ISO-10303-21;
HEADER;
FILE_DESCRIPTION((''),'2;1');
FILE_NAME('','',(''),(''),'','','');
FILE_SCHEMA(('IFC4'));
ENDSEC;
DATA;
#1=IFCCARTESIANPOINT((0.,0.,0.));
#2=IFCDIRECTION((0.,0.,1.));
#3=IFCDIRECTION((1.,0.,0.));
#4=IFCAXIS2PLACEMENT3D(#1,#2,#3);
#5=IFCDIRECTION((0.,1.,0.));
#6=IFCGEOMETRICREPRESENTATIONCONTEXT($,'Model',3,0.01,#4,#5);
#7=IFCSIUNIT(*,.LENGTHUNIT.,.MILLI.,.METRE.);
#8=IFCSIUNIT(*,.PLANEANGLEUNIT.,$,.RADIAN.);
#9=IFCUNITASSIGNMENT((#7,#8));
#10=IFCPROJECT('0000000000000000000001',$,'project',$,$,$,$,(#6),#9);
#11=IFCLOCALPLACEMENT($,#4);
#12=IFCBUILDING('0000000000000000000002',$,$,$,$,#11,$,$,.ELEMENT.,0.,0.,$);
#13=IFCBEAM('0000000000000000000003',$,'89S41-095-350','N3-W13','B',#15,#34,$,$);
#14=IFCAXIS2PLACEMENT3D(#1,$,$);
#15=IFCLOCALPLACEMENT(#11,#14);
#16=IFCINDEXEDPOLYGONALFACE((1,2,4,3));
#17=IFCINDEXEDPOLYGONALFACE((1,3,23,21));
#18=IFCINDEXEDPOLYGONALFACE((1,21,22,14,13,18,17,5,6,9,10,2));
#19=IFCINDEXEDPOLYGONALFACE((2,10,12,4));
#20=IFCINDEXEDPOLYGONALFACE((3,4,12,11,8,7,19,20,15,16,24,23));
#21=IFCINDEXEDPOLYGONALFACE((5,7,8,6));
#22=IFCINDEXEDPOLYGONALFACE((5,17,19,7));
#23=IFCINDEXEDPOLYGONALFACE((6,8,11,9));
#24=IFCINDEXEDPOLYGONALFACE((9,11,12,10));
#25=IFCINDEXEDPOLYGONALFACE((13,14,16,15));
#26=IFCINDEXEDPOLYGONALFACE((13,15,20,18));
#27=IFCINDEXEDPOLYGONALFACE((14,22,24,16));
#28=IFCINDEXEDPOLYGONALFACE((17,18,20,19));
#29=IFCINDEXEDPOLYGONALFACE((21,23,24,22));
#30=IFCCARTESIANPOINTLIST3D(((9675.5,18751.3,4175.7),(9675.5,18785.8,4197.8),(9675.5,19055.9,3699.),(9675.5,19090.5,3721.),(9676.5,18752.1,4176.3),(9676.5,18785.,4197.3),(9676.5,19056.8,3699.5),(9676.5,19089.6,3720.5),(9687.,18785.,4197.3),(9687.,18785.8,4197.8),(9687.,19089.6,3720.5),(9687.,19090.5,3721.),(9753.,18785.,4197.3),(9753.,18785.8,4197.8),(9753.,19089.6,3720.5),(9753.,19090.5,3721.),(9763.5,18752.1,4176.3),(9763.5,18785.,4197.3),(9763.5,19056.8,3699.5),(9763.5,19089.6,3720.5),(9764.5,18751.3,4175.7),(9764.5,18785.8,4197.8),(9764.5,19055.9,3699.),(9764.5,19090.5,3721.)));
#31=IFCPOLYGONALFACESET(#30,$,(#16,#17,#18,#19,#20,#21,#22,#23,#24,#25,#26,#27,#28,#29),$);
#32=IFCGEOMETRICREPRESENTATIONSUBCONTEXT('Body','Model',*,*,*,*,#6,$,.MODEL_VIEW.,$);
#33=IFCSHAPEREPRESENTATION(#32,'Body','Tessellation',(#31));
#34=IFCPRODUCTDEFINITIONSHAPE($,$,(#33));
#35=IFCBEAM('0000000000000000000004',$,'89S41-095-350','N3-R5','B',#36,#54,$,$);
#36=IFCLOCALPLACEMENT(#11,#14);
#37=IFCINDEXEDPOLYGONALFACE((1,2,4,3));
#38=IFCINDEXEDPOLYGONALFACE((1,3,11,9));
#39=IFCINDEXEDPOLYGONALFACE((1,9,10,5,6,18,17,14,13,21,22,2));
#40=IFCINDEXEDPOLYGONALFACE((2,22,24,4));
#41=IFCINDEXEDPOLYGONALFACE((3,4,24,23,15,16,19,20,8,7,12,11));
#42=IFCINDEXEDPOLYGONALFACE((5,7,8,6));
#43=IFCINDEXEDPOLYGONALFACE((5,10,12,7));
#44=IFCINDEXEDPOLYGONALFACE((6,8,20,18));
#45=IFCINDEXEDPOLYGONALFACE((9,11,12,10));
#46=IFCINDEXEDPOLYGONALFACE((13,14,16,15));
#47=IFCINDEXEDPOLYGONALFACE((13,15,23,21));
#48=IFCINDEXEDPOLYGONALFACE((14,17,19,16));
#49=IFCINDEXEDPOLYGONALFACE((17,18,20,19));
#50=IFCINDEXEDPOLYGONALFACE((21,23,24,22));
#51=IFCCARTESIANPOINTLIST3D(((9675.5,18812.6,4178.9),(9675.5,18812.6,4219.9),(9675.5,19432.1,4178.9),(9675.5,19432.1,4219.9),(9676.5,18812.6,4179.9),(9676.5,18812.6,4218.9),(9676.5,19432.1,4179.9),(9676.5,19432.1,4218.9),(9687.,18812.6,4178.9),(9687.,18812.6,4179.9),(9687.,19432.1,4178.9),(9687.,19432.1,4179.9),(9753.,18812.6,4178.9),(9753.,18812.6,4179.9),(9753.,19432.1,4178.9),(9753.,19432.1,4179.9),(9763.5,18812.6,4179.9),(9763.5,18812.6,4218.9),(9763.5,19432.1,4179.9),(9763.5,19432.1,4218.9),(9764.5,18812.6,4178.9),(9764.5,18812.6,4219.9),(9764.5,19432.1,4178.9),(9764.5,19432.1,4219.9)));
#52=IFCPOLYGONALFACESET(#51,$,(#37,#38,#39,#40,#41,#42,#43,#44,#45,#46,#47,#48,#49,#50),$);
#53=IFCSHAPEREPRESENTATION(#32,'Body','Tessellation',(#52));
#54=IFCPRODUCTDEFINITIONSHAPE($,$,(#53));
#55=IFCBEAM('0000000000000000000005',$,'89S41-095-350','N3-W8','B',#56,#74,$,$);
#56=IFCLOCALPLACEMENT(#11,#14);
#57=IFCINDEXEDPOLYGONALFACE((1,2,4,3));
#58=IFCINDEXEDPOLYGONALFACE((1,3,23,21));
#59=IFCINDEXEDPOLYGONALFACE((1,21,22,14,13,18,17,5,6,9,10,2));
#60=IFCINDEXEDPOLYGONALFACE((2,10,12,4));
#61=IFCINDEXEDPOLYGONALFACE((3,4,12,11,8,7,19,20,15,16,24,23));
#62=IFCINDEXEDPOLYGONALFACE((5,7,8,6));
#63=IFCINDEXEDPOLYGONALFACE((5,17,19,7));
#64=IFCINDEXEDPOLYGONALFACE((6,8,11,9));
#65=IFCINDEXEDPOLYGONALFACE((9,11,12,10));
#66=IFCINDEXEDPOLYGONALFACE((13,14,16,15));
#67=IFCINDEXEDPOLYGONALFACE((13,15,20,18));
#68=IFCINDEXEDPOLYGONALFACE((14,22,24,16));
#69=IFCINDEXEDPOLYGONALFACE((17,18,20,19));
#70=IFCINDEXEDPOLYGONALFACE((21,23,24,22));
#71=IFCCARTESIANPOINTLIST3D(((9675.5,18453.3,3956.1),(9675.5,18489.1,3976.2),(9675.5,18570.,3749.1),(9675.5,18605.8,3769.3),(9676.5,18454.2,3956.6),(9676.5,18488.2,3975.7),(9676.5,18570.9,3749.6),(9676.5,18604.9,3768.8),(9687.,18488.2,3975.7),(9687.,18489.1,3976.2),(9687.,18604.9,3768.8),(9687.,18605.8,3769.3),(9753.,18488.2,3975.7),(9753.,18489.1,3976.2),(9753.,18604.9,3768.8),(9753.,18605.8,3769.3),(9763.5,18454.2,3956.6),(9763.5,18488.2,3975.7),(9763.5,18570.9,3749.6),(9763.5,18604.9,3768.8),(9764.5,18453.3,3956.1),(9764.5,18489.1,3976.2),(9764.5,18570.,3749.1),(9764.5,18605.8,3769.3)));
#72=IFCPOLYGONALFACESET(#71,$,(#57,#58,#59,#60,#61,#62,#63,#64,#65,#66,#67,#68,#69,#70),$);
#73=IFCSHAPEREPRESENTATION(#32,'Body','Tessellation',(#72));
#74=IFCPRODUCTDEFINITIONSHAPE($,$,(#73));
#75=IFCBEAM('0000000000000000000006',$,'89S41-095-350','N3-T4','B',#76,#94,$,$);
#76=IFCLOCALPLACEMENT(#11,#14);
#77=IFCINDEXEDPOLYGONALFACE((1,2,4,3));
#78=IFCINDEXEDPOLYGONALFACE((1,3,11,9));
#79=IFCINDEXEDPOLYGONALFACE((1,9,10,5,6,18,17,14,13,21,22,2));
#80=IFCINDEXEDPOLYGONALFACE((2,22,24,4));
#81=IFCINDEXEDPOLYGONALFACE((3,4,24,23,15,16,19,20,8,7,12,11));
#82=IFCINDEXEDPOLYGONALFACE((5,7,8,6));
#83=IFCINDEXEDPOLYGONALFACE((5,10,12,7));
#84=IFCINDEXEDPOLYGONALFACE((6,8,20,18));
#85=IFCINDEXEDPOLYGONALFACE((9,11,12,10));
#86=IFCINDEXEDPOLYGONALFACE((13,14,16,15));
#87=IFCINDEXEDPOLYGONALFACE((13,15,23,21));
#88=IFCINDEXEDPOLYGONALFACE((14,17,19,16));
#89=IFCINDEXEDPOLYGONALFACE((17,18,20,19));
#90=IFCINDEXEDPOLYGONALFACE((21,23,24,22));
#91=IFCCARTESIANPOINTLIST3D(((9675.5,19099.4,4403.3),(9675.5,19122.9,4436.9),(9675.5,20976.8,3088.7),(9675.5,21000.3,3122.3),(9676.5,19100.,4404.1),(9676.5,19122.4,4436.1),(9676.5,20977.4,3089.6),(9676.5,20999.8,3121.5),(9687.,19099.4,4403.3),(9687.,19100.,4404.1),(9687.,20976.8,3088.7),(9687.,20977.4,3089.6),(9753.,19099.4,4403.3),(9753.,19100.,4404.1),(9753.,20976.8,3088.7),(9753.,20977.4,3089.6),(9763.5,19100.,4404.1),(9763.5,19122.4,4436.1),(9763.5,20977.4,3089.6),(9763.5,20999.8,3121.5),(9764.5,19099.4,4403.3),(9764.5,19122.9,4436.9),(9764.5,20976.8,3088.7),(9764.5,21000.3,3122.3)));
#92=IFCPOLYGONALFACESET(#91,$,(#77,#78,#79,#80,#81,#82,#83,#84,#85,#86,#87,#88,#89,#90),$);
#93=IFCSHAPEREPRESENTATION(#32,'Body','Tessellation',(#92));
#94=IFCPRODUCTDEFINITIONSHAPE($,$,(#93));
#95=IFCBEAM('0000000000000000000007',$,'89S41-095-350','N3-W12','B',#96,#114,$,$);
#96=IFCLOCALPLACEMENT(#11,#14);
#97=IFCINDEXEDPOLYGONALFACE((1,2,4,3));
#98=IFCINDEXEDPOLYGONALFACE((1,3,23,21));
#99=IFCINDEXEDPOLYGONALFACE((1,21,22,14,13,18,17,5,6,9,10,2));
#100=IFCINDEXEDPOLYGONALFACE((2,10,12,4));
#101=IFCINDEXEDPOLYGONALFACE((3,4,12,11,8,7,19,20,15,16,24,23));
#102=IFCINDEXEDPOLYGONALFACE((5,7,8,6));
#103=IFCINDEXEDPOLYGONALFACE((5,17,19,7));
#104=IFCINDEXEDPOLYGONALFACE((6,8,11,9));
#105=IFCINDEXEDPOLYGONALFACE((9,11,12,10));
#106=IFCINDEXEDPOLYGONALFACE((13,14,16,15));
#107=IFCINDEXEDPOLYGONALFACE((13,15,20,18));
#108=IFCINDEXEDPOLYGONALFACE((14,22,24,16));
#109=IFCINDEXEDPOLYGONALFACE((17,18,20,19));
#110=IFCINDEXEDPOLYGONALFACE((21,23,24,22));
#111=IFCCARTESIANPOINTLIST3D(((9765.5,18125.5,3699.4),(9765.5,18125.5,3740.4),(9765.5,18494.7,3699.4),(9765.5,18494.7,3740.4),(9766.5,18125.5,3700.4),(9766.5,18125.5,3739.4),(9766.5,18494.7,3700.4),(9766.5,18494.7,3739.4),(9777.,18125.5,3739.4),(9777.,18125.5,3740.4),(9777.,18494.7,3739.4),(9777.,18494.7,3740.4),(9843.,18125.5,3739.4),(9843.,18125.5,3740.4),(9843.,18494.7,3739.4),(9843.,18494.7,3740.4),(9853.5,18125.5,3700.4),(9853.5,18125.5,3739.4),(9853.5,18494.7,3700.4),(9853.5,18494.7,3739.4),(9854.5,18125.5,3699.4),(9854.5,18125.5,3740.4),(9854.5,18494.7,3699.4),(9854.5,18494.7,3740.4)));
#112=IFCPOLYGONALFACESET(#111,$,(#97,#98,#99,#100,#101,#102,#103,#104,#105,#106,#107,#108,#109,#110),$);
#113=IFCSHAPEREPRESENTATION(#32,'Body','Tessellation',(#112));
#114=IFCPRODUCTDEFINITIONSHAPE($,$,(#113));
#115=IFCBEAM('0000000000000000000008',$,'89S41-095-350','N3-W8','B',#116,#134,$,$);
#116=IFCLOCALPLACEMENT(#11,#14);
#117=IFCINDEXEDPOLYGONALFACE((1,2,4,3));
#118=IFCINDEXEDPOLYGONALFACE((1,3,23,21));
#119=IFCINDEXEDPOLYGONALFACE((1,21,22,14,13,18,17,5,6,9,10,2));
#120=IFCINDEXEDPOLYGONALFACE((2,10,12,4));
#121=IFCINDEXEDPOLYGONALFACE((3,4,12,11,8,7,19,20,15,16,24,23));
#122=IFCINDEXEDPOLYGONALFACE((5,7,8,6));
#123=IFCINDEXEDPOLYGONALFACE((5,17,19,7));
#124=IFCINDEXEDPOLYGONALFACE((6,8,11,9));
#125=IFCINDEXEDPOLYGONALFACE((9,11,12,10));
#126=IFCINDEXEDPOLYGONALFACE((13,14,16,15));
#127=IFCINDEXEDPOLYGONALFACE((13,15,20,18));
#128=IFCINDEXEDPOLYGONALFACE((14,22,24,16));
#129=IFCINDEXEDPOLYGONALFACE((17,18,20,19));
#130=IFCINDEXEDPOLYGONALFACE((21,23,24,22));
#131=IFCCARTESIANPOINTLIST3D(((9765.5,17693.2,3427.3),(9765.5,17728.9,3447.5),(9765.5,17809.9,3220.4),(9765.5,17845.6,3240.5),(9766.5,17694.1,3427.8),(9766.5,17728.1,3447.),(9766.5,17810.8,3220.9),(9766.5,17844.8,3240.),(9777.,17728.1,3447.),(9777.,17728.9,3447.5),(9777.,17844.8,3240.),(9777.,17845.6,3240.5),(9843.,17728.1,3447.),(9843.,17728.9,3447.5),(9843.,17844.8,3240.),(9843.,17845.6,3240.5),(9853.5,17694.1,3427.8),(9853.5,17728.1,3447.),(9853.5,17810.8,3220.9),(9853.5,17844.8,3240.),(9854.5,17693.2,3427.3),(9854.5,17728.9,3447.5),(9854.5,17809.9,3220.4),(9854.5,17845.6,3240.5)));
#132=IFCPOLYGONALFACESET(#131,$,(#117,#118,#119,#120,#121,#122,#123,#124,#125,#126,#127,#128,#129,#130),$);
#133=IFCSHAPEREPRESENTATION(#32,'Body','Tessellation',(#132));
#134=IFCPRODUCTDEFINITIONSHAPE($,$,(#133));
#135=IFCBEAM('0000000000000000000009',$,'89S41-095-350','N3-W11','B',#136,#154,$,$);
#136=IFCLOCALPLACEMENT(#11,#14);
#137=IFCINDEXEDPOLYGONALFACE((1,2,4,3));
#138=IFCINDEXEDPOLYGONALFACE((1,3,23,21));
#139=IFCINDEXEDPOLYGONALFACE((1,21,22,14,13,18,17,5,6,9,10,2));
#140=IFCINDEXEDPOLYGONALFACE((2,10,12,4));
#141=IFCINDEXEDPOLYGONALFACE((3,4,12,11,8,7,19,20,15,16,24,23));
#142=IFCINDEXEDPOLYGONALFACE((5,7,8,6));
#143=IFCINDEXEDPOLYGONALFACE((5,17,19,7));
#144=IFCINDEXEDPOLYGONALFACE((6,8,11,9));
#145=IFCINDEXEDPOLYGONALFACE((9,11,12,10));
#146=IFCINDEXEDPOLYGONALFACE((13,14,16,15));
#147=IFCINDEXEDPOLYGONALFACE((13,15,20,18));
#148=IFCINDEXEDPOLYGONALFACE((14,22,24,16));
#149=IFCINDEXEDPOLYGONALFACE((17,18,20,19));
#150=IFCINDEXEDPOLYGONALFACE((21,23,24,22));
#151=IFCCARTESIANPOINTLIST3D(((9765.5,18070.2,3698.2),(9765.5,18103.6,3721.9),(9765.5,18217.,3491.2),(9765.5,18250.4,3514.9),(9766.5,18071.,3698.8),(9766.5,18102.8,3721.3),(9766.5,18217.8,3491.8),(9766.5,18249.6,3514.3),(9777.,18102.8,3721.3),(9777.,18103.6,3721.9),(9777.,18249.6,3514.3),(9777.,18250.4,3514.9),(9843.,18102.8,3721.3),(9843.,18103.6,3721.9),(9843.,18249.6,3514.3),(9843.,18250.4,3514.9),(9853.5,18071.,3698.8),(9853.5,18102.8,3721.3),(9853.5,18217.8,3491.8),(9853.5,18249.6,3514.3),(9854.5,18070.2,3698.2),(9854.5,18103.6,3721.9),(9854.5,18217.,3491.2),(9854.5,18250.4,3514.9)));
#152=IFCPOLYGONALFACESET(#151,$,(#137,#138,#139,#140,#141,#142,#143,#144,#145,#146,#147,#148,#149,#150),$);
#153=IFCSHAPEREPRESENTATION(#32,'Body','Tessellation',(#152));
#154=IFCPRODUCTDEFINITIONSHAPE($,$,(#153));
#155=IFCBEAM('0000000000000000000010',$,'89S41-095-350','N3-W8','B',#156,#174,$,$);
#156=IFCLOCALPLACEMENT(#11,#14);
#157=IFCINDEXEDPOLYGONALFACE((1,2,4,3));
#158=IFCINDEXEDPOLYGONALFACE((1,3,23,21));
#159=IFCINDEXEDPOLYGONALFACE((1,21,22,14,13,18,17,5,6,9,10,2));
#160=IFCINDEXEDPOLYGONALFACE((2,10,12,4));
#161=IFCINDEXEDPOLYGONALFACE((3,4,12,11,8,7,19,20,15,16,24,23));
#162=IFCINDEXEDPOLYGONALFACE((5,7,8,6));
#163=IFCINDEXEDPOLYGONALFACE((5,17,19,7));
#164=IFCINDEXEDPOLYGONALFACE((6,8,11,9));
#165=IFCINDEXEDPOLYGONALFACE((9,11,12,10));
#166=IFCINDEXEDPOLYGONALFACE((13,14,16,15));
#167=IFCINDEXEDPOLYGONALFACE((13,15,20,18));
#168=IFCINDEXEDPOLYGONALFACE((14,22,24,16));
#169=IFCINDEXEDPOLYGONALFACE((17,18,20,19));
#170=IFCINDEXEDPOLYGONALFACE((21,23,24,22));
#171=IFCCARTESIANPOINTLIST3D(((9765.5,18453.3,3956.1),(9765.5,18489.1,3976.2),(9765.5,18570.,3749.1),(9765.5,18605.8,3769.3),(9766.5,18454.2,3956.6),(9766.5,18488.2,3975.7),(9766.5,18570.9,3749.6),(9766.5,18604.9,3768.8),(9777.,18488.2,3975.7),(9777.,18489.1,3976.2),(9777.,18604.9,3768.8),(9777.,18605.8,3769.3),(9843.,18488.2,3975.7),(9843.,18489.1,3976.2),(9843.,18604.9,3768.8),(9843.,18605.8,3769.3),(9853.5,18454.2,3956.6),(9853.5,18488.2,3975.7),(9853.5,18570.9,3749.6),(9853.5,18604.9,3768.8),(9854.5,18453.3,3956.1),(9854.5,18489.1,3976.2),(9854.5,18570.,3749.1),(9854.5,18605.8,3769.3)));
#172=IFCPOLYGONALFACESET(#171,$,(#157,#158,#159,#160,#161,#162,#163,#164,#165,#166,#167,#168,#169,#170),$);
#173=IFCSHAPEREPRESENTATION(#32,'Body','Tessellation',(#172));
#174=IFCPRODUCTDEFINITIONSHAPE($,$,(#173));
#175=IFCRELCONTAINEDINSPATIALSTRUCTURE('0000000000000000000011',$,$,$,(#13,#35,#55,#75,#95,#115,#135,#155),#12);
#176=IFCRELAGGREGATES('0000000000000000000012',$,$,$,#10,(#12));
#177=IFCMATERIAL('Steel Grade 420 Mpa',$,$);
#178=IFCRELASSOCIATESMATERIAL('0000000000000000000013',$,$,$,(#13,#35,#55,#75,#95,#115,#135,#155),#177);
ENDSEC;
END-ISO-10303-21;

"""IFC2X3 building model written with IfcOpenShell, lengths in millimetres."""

from ifc_helpers import new_model, si_unit, direction, frame, origin, origin_with_axes, origin_2d_with_axis, place, context, subcontext, project, spatial, c_section, extrude, source, transform, mapped, material, element, save


model = new_model("IFC2X3")

# Units and contexts
model_context = context("Model", 3, precision=0.01, world=origin_with_axes(), true_north=direction((0.0, 1.0, 0.0)))
body_context = subcontext(model_context, "Body", "Model", "MODEL_VIEW")
ifc_project = project(units=[si_unit("LENGTHUNIT", "METRE", prefix="MILLI"), si_unit("PLANEANGLEUNIT", "RADIAN")], contexts=[model_context])

# Building
building_placement = place(None, origin_with_axes())
building = spatial("IfcBuilding", under=ifc_project, at=building_placement, CompositionType="ELEMENT", ElevationOfRefHeight=0.0, ElevationOfTerrain=0.0)

# Shared definitions
ifc_material = material(Name="Steel Grade 420 Mpa")

# Beams
shared_shape_1 = source(origin(), body_context, "Body", "SweptSolid", [
    extrude(c_section(Depth=89.0, Width=41.0, WallThickness=1.0, Girth=11.5, at=origin_2d_with_axis()), origin_with_axes(), (0.0, 0.0, 1.0), 565.8),
])
beam_1_placement = place(None, frame((9720.0, 19073.2, 3710.0), z_axis=(0.0, -0.538498, 0.842627), x_axis=(0.0, 0.842627, 0.538498)))
element("IfcBeam", 1, at=beam_1_placement, inside=building, material=ifc_material, Name="89S41-095-350", Description="N3-W13", ObjectType="B", context=body_context, shape_type="MappedRepresentation", body=[
    mapped(shared_shape_1, transform((0.0, 0.0, 0.0), scale=1.0)),
])
shared_shape_2 = source(origin(), body_context, "Body", "SweptSolid", [
    extrude(c_section(Depth=89.0, Width=41.0, WallThickness=1.0, Girth=11.5, at=origin_2d_with_axis()), origin_with_axes(), (0.0, 0.0, 1.0), 619.5),
])
beam_2_placement = place(None, frame((9720.0, 18812.6, 4199.4), z_axis=(0.0, 1.0, 0.0), x_axis=(0.0, 0.0, -1.0)))
element("IfcBeam", 2, at=beam_2_placement, inside=building, material=ifc_material, Name="89S41-095-350", Description="N3-R5", ObjectType="B", context=body_context, shape_type="MappedRepresentation", body=[
    mapped(shared_shape_2, transform((0.0, 0.0, 0.0), scale=1.0)),
])
shared_shape_3 = source(origin(), body_context, "Body", "SweptSolid", [
    extrude(c_section(Depth=89.0, Width=41.0, WallThickness=1.0, Girth=11.5, at=origin_2d_with_axis()), origin_with_axes(), (0.0, 0.0, 1.0), 237.6),
])
beam_3_placement = place(None, frame((9720.0, 18587.9, 3759.2), z_axis=(0.0, -0.491169, 0.871064), x_axis=(0.0, 0.871064, 0.491169)))
element("IfcBeam", 3, at=beam_3_placement, inside=building, material=ifc_material, Name="89S41-095-350", Description="N3-W8", ObjectType="B", context=body_context, shape_type="MappedRepresentation", body=[
    mapped(shared_shape_3, transform((0.0, 0.0, 0.0), scale=1.0)),
])
shared_shape_4 = source(origin(), body_context, "Body", "SweptSolid", [
    extrude(c_section(Depth=89.0, Width=41.0, WallThickness=1.0, Girth=11.5, at=origin_2d_with_axis()), origin_with_axes(), (0.0, 0.0, 1.0), 2291.9),
])
beam_4_placement = place(None, frame((9720.0, 19111.2, 4420.1), z_axis=(0.0, 0.819152, -0.573576), x_axis=(0.0, -0.573576, -0.819152)))
element("IfcBeam", 4, at=beam_4_placement, inside=building, material=ifc_material, Name="89S41-095-350", Description="N3-T4", ObjectType="B", context=body_context, shape_type="MappedRepresentation", body=[
    mapped(shared_shape_4, transform((0.0, 0.0, 0.0), scale=1.0)),
])
shared_shape_5 = source(origin(), body_context, "Body", "SweptSolid", [
    extrude(c_section(Depth=89.0, Width=41.0, WallThickness=1.0, Girth=11.5, at=origin_2d_with_axis()), origin_with_axes(), (0.0, 0.0, 1.0), 369.2),
])
beam_5_placement = place(None, frame((9810.0, 18494.7, 3719.9), z_axis=(0.0, -1.0, 0.0), x_axis=(0.0, 0.0, 1.0)))
element("IfcBeam", 5, at=beam_5_placement, inside=building, material=ifc_material, Name="89S41-095-350", Description="N3-W12", ObjectType="B", context=body_context, shape_type="MappedRepresentation", body=[
    mapped(shared_shape_5, transform((0.0, 0.0, 0.0), scale=1.0)),
])
shared_shape_6 = source(origin(), body_context, "Body", "SweptSolid", [
    extrude(c_section(Depth=89.0, Width=41.0, WallThickness=1.0, Girth=11.5, at=origin_2d_with_axis()), origin_with_axes(), (0.0, 0.0, 1.0), 237.6),
])
beam_6_placement = place(None, frame((9810.0, 17827.8, 3230.5), z_axis=(0.0, -0.491169, 0.871064), x_axis=(0.0, 0.871064, 0.491169)))
element("IfcBeam", 6, at=beam_6_placement, inside=building, material=ifc_material, Name="89S41-095-350", Description="N3-W8", ObjectType="B", context=body_context, shape_type="MappedRepresentation", body=[
    mapped(shared_shape_6, transform((0.0, 0.0, 0.0), scale=1.0)),
])
shared_shape_7 = source(origin(), body_context, "Body", "SweptSolid", [
    extrude(c_section(Depth=89.0, Width=41.0, WallThickness=1.0, Girth=11.5, at=origin_2d_with_axis()), origin_with_axes(), (0.0, 0.0, 1.0), 253.8),
])
beam_7_placement = place(None, frame((9810.0, 18233.7, 3503.0), z_axis=(0.0, -0.578484, 0.815694), x_axis=(0.0, 0.815694, 0.578484)))
element("IfcBeam", 7, at=beam_7_placement, inside=building, material=ifc_material, Name="89S41-095-350", Description="N3-W11", ObjectType="B", context=body_context, shape_type="MappedRepresentation", body=[
    mapped(shared_shape_7, transform((0.0, 0.0, 0.0), scale=1.0)),
])
shared_shape_8 = source(origin(), body_context, "Body", "SweptSolid", [
    extrude(c_section(Depth=89.0, Width=41.0, WallThickness=1.0, Girth=11.5, at=origin_2d_with_axis()), origin_with_axes(), (0.0, 0.0, 1.0), 237.6),
])
beam_8_placement = place(None, frame((9810.0, 18587.9, 3759.2), z_axis=(0.0, -0.491169, 0.871064), x_axis=(0.0, 0.871064, 0.491169)))
element("IfcBeam", 8, at=beam_8_placement, inside=building, material=ifc_material, Name="89S41-095-350", Description="N3-W8", ObjectType="B", context=body_context, shape_type="MappedRepresentation", body=[
    mapped(shared_shape_8, transform((0.0, 0.0, 0.0), scale=1.0)),
])

save(model, "model.ifc")
